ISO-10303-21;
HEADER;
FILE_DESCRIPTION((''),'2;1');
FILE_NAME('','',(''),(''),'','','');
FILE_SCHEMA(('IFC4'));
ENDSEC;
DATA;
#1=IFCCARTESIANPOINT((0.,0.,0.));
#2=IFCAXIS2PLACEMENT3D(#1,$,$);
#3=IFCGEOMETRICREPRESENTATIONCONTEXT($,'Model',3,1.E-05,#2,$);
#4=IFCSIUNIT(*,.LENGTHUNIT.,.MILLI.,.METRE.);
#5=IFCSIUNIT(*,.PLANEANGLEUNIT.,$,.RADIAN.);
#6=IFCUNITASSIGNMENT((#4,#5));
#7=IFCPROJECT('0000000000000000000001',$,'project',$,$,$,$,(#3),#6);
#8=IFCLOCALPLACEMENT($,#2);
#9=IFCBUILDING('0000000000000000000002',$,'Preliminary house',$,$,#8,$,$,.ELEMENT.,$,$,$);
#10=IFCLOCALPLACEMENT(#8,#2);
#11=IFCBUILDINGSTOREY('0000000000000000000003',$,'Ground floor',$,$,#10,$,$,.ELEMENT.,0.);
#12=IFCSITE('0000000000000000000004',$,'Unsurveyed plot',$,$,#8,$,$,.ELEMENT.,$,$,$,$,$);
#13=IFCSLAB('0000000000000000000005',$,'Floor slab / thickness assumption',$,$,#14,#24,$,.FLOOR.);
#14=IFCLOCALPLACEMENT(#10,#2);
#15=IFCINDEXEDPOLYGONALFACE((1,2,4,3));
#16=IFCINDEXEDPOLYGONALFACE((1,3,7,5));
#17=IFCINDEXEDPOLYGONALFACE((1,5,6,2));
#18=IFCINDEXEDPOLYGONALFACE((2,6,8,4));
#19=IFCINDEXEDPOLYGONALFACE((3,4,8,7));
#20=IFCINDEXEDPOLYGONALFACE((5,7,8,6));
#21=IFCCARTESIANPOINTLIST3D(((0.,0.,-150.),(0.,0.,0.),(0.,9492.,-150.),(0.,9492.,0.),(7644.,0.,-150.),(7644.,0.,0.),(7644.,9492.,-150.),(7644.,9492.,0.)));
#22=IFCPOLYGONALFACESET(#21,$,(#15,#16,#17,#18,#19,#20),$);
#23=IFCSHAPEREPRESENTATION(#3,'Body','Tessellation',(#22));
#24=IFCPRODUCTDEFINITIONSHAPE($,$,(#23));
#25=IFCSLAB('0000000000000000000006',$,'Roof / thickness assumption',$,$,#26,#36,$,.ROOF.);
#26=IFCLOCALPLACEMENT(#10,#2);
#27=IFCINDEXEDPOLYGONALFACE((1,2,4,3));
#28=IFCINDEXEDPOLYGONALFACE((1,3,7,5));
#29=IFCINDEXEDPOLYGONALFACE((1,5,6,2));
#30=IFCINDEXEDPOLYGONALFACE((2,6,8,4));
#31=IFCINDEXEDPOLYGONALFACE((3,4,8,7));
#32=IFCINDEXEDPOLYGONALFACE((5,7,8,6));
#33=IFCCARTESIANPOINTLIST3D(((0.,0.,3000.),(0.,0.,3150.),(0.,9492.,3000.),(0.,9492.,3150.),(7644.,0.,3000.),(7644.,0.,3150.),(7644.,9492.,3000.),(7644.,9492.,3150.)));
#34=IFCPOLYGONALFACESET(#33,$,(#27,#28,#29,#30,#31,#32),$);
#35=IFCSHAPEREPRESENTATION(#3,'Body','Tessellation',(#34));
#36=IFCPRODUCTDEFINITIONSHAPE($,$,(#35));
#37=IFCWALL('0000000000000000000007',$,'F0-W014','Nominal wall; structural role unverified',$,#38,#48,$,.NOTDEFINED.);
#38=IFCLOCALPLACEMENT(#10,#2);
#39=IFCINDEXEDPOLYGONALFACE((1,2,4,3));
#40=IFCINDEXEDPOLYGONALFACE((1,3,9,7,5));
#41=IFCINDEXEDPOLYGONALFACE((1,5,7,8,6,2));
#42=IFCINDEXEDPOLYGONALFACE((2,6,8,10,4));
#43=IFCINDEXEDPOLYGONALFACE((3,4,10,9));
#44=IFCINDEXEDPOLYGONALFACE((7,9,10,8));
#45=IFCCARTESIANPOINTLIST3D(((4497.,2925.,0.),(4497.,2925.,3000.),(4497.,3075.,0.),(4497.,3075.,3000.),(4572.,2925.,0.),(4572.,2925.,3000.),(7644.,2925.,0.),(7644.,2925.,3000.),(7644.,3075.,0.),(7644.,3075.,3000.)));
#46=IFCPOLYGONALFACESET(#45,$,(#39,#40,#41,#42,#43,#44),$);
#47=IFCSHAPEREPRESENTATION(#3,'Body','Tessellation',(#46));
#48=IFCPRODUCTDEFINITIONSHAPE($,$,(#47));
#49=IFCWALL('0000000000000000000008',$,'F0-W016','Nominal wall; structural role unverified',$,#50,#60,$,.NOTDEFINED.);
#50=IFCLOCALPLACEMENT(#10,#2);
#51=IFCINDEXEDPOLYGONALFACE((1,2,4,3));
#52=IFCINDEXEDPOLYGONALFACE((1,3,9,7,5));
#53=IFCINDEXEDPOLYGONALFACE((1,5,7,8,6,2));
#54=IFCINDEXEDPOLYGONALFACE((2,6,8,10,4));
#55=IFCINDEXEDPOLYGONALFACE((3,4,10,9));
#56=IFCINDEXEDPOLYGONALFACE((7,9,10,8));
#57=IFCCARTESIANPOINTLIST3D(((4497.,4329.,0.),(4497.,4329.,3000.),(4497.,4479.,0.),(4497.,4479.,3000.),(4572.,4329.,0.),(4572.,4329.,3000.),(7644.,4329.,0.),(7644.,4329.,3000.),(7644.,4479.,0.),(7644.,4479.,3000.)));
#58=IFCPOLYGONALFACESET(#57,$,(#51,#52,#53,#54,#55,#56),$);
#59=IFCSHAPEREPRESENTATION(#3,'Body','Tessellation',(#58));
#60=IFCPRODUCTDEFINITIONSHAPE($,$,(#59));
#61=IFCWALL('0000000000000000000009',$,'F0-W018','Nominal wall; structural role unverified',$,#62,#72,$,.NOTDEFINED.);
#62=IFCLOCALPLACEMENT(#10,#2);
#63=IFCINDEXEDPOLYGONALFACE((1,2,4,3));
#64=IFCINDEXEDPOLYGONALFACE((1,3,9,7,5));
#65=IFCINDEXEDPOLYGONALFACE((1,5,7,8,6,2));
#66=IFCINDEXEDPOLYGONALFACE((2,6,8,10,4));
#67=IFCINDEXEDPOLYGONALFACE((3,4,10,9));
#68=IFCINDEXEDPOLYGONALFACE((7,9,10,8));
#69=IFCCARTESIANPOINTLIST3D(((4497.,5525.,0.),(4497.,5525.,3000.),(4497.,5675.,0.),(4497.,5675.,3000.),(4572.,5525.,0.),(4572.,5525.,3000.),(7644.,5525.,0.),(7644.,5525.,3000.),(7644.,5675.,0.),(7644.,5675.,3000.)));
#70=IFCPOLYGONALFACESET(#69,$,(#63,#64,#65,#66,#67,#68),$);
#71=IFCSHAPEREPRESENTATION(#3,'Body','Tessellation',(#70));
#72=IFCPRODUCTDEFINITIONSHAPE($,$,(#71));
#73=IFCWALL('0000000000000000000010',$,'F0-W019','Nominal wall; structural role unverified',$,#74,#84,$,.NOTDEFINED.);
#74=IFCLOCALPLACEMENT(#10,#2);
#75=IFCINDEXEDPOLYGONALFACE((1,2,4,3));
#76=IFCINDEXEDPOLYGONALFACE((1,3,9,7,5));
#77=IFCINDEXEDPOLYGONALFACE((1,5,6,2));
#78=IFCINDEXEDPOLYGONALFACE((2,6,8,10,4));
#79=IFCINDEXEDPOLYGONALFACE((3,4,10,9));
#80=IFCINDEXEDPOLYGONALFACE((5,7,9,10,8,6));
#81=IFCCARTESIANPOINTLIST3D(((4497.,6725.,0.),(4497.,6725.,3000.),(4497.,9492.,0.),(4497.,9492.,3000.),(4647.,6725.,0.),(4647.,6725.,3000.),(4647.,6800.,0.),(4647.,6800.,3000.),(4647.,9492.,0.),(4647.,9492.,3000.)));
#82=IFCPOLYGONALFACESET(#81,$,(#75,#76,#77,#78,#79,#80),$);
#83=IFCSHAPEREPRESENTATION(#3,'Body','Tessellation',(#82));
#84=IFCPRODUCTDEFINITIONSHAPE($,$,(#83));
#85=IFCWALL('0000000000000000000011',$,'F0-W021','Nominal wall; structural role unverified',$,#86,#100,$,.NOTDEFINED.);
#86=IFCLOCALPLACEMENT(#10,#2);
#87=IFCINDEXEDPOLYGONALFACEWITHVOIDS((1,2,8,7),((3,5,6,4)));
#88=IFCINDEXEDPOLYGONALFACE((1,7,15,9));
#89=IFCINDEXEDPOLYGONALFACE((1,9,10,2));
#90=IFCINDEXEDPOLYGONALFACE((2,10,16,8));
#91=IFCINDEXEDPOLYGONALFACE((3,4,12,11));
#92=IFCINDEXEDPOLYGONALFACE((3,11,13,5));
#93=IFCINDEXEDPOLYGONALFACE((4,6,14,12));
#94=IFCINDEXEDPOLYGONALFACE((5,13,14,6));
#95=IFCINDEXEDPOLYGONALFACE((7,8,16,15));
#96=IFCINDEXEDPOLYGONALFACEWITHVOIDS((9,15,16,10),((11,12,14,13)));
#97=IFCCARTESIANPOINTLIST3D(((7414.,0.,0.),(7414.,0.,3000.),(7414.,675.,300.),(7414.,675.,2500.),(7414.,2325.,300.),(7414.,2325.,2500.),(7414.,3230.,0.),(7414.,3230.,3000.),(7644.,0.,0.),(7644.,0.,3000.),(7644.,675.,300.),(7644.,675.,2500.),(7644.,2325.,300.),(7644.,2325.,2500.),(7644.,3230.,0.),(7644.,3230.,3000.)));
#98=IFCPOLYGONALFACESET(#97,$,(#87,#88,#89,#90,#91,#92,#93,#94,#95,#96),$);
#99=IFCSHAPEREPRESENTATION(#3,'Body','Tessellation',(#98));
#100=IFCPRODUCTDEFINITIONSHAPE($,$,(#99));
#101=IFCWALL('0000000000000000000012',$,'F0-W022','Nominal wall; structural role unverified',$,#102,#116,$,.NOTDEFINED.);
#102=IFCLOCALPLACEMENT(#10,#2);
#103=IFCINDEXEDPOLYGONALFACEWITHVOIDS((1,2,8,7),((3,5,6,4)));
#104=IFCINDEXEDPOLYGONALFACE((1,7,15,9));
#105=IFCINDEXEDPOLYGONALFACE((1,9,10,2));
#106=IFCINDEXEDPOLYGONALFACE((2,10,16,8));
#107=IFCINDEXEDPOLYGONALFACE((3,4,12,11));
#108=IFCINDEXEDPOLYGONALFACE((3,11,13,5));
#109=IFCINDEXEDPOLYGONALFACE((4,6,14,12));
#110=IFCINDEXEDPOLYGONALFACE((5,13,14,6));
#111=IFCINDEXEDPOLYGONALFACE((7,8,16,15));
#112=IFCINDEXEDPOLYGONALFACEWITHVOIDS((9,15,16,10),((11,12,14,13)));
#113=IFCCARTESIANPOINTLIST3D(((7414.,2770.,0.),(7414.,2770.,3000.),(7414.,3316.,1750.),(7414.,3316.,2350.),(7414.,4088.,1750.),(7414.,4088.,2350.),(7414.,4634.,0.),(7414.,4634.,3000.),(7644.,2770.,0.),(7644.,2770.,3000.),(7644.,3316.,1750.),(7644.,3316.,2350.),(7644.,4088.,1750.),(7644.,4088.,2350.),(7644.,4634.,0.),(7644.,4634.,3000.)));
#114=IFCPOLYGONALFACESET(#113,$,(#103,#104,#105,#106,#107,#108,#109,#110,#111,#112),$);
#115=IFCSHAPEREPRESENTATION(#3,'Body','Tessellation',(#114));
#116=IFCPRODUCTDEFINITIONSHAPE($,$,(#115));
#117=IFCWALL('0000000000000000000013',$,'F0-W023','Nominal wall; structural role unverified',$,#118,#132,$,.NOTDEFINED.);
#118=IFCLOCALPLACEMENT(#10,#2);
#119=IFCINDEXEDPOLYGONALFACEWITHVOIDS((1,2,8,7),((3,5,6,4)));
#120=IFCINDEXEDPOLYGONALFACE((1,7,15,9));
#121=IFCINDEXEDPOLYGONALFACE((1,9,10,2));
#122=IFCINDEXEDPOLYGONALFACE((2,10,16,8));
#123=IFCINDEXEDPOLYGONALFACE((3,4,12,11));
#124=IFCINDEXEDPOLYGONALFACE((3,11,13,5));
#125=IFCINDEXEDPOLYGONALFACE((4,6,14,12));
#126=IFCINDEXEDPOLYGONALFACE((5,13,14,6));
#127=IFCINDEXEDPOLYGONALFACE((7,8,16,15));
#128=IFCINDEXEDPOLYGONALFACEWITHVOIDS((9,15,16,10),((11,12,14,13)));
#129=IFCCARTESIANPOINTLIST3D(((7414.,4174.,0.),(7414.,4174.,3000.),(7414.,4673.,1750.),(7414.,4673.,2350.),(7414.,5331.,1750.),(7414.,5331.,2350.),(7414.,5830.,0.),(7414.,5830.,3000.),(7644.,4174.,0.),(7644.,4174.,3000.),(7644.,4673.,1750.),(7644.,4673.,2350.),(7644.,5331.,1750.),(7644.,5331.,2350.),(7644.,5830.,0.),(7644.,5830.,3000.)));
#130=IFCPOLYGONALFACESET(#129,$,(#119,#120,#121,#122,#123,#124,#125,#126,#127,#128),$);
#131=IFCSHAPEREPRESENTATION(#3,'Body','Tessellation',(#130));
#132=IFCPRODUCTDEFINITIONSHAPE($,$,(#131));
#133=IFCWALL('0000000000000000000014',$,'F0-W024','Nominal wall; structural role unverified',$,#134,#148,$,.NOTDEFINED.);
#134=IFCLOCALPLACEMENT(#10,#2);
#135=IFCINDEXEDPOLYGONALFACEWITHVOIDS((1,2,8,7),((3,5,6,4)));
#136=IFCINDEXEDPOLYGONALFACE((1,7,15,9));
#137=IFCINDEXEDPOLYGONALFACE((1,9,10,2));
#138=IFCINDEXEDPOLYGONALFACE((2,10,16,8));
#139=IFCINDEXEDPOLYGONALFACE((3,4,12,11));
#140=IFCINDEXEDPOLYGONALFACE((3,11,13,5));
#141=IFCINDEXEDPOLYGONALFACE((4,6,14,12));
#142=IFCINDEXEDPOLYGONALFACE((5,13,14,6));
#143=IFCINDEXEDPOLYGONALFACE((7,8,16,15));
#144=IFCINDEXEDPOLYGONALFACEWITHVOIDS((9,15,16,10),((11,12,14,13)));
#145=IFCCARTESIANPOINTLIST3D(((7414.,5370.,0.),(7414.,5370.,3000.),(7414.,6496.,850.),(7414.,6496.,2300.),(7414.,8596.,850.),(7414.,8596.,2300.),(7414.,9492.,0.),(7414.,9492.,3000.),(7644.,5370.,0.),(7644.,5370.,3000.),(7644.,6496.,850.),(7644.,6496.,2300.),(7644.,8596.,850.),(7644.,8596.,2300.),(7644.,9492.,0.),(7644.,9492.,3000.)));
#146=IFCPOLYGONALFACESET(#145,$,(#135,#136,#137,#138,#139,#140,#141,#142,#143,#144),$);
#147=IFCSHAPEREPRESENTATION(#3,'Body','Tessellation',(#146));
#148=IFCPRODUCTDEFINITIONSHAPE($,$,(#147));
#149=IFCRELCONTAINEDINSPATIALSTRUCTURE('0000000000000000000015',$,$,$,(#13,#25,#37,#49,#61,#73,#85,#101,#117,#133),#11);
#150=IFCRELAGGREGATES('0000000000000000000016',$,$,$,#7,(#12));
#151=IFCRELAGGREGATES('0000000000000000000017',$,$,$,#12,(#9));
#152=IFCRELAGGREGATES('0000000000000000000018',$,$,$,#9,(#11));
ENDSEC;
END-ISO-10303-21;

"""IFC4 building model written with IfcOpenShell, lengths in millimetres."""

from ifc_helpers import new_model, si_unit, frame, origin, place, context, project, spatial, polyline, outline, extrude, element, save


model = new_model("IFC4")

# Units and contexts
model_context = context("Model", 3, precision=1e-05, world=origin())
ifc_project = project(units=[si_unit("LENGTHUNIT", "METRE", prefix="MILLI"), si_unit("PLANEANGLEUNIT", "RADIAN")], contexts=[model_context])

# Site, building, storey
placement_1 = place(None, origin())
site = spatial("IfcSite", under=ifc_project, at=placement_1, Name="Unsurveyed plot", CompositionType="ELEMENT")
building = spatial("IfcBuilding", under=site, at=placement_1, Name="Preliminary house", CompositionType="ELEMENT")
placement_2 = place(placement_1, origin())
storey = spatial("IfcBuildingStorey", under=building, at=placement_2, Name="Ground floor", CompositionType="ELEMENT", Elevation=0.0)

# Slabs
element("IfcSlab", 1, at=placement_2, inside=storey, Name="Floor slab / thickness assumption", PredefinedType="FLOOR", context=model_context, shape_type="SweptSolid", body=[
    extrude(outline(polyline([(7644.0, 0.0), (7644.0, 9492.0), (0.0, 9492.0), (0.0, 0.0), (7644.0, 0.0)])), frame((0.0, 0.0, -150.0)), (0.0, 0.0, 1.0), 150.0),
])
element("IfcSlab", 2, at=placement_2, inside=storey, Name="Roof / thickness assumption", PredefinedType="ROOF", context=model_context, shape_type="SweptSolid", body=[
    extrude(outline(polyline([(7644.0, 0.0), (7644.0, 9492.0), (0.0, 9492.0), (0.0, 0.0), (7644.0, 0.0)])), frame((0.0, 0.0, 3000.0)), (0.0, 0.0, 1.0), 150.0),
])

# Wall
element("IfcWall", 3, at=placement_2, inside=storey, Name="F0-W014", Description="Nominal wall; structural role unverified", PredefinedType="NOTDEFINED", context=model_context, shape_type="SweptSolid", body=[
    extrude(outline(polyline([(4572.0, 2925.0), (4497.0, 2925.0), (4497.0, 3075.0), (7644.0, 3075.0), (7644.0, 2925.0), (4572.0, 2925.0)])), origin(), (0.0, 0.0, 1.0), 3000.0),
])

# Wall
element("IfcWall", 4, at=placement_2, inside=storey, Name="F0-W016", Description="Nominal wall; structural role unverified", PredefinedType="NOTDEFINED", context=model_context, shape_type="SweptSolid", body=[
    extrude(outline(polyline([(4572.0, 4329.0), (4497.0, 4329.0), (4497.0, 4479.0), (7644.0, 4479.0), (7644.0, 4329.0), (4572.0, 4329.0)])), origin(), (0.0, 0.0, 1.0), 3000.0),
])

# Walls
element("IfcWall", 5, at=placement_2, inside=storey, Name="F0-W018", Description="Nominal wall; structural role unverified", PredefinedType="NOTDEFINED", context=model_context, shape_type="SweptSolid", body=[
    extrude(outline(polyline([(4572.0, 5525.0), (4497.0, 5525.0), (4497.0, 5675.0), (7644.0, 5675.0), (7644.0, 5525.0), (4572.0, 5525.0)])), origin(), (0.0, 0.0, 1.0), 3000.0),
])
element("IfcWall", 6, at=placement_2, inside=storey, Name="F0-W019", Description="Nominal wall; structural role unverified", PredefinedType="NOTDEFINED", context=model_context, shape_type="SweptSolid", body=[
    extrude(outline(polyline([(4647.0, 6800.0), (4647.0, 6725.0), (4497.0, 6725.0), (4497.0, 9492.0), (4647.0, 9492.0), (4647.0, 6800.0)])), origin(), (0.0, 0.0, 1.0), 3000.0),
])

# Walls, openings
wall_1 = element("IfcWall", 7, at=placement_2, inside=storey, Name="F0-W021", Description="Nominal wall; structural role unverified", PredefinedType="NOTDEFINED", context=model_context, shape_type="SweptSolid", body=[
    extrude(outline(polyline([(7414.0, 3230.0), (7644.0, 3230.0), (7644.0, 0.0), (7414.0, 0.0), (7414.0, 3000.0), (7414.0, 3230.0)])), origin(), (0.0, 0.0, 1.0), 3000.0),
])
element("IfcOpeningElement", 8, at=placement_2, cuts=wall_1, PredefinedType="OPENING", context=model_context, shape_type="SweptSolid", body=[
    extrude(outline(polyline([(8059.0, 675.0), (8059.0, 2325.0), (6999.0, 2325.0), (6999.0, 675.0), (8059.0, 675.0)])), frame((0.0, 0.0, 300.0)), (0.0, 0.0, 1.0), 2200.0),
])
wall_2 = element("IfcWall", 9, at=placement_2, inside=storey, Name="F0-W022", Description="Nominal wall; structural role unverified", PredefinedType="NOTDEFINED", context=model_context, shape_type="SweptSolid", body=[
    extrude(outline(polyline([(7414.0, 4634.0), (7644.0, 4634.0), (7644.0, 2770.0), (7414.0, 2770.0), (7414.0, 4404.0), (7414.0, 4634.0)])), origin(), (0.0, 0.0, 1.0), 3000.0),
])
element("IfcOpeningElement", 10, at=placement_2, cuts=wall_2, PredefinedType="OPENING", context=model_context, shape_type="SweptSolid", body=[
    extrude(outline(polyline([(8059.0, 3316.0), (8059.0, 4088.0), (6999.0, 4088.0), (6999.0, 3316.0), (8059.0, 3316.0)])), frame((0.0, 0.0, 1750.0)), (0.0, 0.0, 1.0), 600.0),
])
wall_3 = element("IfcWall", 11, at=placement_2, inside=storey, Name="F0-W023", Description="Nominal wall; structural role unverified", PredefinedType="NOTDEFINED", context=model_context, shape_type="SweptSolid", body=[
    extrude(outline(polyline([(7414.0, 5830.0), (7644.0, 5830.0), (7644.0, 4174.0), (7414.0, 4174.0), (7414.0, 5600.0), (7414.0, 5830.0)])), origin(), (0.0, 0.0, 1.0), 3000.0),
])
element("IfcOpeningElement", 12, at=placement_2, cuts=wall_3, PredefinedType="OPENING", context=model_context, shape_type="SweptSolid", body=[
    extrude(outline(polyline([(8059.0, 4673.0), (8059.0, 5331.0), (6999.0, 5331.0), (6999.0, 4673.0), (8059.0, 4673.0)])), frame((0.0, 0.0, 1750.0)), (0.0, 0.0, 1.0), 600.0),
])
wall_4 = element("IfcWall", 13, at=placement_2, inside=storey, Name="F0-W024", Description="Nominal wall; structural role unverified", PredefinedType="NOTDEFINED", context=model_context, shape_type="SweptSolid", body=[
    extrude(outline(polyline([(7414.0, 5370.0), (7414.0, 9492.0), (7644.0, 9492.0), (7644.0, 5370.0), (7414.0, 5370.0)])), origin(), (0.0, 0.0, 1.0), 3000.0),
])
element("IfcOpeningElement", 14, at=placement_2, cuts=wall_4, PredefinedType="OPENING", context=model_context, shape_type="SweptSolid", body=[
    extrude(outline(polyline([(8059.0, 6496.0), (8059.0, 8596.0), (6999.0, 8596.0), (6999.0, 6496.0), (8059.0, 6496.0)])), frame((0.0, 0.0, 850.0)), (0.0, 0.0, 1.0), 1450.0),
])

save(model, "model.ifc")
